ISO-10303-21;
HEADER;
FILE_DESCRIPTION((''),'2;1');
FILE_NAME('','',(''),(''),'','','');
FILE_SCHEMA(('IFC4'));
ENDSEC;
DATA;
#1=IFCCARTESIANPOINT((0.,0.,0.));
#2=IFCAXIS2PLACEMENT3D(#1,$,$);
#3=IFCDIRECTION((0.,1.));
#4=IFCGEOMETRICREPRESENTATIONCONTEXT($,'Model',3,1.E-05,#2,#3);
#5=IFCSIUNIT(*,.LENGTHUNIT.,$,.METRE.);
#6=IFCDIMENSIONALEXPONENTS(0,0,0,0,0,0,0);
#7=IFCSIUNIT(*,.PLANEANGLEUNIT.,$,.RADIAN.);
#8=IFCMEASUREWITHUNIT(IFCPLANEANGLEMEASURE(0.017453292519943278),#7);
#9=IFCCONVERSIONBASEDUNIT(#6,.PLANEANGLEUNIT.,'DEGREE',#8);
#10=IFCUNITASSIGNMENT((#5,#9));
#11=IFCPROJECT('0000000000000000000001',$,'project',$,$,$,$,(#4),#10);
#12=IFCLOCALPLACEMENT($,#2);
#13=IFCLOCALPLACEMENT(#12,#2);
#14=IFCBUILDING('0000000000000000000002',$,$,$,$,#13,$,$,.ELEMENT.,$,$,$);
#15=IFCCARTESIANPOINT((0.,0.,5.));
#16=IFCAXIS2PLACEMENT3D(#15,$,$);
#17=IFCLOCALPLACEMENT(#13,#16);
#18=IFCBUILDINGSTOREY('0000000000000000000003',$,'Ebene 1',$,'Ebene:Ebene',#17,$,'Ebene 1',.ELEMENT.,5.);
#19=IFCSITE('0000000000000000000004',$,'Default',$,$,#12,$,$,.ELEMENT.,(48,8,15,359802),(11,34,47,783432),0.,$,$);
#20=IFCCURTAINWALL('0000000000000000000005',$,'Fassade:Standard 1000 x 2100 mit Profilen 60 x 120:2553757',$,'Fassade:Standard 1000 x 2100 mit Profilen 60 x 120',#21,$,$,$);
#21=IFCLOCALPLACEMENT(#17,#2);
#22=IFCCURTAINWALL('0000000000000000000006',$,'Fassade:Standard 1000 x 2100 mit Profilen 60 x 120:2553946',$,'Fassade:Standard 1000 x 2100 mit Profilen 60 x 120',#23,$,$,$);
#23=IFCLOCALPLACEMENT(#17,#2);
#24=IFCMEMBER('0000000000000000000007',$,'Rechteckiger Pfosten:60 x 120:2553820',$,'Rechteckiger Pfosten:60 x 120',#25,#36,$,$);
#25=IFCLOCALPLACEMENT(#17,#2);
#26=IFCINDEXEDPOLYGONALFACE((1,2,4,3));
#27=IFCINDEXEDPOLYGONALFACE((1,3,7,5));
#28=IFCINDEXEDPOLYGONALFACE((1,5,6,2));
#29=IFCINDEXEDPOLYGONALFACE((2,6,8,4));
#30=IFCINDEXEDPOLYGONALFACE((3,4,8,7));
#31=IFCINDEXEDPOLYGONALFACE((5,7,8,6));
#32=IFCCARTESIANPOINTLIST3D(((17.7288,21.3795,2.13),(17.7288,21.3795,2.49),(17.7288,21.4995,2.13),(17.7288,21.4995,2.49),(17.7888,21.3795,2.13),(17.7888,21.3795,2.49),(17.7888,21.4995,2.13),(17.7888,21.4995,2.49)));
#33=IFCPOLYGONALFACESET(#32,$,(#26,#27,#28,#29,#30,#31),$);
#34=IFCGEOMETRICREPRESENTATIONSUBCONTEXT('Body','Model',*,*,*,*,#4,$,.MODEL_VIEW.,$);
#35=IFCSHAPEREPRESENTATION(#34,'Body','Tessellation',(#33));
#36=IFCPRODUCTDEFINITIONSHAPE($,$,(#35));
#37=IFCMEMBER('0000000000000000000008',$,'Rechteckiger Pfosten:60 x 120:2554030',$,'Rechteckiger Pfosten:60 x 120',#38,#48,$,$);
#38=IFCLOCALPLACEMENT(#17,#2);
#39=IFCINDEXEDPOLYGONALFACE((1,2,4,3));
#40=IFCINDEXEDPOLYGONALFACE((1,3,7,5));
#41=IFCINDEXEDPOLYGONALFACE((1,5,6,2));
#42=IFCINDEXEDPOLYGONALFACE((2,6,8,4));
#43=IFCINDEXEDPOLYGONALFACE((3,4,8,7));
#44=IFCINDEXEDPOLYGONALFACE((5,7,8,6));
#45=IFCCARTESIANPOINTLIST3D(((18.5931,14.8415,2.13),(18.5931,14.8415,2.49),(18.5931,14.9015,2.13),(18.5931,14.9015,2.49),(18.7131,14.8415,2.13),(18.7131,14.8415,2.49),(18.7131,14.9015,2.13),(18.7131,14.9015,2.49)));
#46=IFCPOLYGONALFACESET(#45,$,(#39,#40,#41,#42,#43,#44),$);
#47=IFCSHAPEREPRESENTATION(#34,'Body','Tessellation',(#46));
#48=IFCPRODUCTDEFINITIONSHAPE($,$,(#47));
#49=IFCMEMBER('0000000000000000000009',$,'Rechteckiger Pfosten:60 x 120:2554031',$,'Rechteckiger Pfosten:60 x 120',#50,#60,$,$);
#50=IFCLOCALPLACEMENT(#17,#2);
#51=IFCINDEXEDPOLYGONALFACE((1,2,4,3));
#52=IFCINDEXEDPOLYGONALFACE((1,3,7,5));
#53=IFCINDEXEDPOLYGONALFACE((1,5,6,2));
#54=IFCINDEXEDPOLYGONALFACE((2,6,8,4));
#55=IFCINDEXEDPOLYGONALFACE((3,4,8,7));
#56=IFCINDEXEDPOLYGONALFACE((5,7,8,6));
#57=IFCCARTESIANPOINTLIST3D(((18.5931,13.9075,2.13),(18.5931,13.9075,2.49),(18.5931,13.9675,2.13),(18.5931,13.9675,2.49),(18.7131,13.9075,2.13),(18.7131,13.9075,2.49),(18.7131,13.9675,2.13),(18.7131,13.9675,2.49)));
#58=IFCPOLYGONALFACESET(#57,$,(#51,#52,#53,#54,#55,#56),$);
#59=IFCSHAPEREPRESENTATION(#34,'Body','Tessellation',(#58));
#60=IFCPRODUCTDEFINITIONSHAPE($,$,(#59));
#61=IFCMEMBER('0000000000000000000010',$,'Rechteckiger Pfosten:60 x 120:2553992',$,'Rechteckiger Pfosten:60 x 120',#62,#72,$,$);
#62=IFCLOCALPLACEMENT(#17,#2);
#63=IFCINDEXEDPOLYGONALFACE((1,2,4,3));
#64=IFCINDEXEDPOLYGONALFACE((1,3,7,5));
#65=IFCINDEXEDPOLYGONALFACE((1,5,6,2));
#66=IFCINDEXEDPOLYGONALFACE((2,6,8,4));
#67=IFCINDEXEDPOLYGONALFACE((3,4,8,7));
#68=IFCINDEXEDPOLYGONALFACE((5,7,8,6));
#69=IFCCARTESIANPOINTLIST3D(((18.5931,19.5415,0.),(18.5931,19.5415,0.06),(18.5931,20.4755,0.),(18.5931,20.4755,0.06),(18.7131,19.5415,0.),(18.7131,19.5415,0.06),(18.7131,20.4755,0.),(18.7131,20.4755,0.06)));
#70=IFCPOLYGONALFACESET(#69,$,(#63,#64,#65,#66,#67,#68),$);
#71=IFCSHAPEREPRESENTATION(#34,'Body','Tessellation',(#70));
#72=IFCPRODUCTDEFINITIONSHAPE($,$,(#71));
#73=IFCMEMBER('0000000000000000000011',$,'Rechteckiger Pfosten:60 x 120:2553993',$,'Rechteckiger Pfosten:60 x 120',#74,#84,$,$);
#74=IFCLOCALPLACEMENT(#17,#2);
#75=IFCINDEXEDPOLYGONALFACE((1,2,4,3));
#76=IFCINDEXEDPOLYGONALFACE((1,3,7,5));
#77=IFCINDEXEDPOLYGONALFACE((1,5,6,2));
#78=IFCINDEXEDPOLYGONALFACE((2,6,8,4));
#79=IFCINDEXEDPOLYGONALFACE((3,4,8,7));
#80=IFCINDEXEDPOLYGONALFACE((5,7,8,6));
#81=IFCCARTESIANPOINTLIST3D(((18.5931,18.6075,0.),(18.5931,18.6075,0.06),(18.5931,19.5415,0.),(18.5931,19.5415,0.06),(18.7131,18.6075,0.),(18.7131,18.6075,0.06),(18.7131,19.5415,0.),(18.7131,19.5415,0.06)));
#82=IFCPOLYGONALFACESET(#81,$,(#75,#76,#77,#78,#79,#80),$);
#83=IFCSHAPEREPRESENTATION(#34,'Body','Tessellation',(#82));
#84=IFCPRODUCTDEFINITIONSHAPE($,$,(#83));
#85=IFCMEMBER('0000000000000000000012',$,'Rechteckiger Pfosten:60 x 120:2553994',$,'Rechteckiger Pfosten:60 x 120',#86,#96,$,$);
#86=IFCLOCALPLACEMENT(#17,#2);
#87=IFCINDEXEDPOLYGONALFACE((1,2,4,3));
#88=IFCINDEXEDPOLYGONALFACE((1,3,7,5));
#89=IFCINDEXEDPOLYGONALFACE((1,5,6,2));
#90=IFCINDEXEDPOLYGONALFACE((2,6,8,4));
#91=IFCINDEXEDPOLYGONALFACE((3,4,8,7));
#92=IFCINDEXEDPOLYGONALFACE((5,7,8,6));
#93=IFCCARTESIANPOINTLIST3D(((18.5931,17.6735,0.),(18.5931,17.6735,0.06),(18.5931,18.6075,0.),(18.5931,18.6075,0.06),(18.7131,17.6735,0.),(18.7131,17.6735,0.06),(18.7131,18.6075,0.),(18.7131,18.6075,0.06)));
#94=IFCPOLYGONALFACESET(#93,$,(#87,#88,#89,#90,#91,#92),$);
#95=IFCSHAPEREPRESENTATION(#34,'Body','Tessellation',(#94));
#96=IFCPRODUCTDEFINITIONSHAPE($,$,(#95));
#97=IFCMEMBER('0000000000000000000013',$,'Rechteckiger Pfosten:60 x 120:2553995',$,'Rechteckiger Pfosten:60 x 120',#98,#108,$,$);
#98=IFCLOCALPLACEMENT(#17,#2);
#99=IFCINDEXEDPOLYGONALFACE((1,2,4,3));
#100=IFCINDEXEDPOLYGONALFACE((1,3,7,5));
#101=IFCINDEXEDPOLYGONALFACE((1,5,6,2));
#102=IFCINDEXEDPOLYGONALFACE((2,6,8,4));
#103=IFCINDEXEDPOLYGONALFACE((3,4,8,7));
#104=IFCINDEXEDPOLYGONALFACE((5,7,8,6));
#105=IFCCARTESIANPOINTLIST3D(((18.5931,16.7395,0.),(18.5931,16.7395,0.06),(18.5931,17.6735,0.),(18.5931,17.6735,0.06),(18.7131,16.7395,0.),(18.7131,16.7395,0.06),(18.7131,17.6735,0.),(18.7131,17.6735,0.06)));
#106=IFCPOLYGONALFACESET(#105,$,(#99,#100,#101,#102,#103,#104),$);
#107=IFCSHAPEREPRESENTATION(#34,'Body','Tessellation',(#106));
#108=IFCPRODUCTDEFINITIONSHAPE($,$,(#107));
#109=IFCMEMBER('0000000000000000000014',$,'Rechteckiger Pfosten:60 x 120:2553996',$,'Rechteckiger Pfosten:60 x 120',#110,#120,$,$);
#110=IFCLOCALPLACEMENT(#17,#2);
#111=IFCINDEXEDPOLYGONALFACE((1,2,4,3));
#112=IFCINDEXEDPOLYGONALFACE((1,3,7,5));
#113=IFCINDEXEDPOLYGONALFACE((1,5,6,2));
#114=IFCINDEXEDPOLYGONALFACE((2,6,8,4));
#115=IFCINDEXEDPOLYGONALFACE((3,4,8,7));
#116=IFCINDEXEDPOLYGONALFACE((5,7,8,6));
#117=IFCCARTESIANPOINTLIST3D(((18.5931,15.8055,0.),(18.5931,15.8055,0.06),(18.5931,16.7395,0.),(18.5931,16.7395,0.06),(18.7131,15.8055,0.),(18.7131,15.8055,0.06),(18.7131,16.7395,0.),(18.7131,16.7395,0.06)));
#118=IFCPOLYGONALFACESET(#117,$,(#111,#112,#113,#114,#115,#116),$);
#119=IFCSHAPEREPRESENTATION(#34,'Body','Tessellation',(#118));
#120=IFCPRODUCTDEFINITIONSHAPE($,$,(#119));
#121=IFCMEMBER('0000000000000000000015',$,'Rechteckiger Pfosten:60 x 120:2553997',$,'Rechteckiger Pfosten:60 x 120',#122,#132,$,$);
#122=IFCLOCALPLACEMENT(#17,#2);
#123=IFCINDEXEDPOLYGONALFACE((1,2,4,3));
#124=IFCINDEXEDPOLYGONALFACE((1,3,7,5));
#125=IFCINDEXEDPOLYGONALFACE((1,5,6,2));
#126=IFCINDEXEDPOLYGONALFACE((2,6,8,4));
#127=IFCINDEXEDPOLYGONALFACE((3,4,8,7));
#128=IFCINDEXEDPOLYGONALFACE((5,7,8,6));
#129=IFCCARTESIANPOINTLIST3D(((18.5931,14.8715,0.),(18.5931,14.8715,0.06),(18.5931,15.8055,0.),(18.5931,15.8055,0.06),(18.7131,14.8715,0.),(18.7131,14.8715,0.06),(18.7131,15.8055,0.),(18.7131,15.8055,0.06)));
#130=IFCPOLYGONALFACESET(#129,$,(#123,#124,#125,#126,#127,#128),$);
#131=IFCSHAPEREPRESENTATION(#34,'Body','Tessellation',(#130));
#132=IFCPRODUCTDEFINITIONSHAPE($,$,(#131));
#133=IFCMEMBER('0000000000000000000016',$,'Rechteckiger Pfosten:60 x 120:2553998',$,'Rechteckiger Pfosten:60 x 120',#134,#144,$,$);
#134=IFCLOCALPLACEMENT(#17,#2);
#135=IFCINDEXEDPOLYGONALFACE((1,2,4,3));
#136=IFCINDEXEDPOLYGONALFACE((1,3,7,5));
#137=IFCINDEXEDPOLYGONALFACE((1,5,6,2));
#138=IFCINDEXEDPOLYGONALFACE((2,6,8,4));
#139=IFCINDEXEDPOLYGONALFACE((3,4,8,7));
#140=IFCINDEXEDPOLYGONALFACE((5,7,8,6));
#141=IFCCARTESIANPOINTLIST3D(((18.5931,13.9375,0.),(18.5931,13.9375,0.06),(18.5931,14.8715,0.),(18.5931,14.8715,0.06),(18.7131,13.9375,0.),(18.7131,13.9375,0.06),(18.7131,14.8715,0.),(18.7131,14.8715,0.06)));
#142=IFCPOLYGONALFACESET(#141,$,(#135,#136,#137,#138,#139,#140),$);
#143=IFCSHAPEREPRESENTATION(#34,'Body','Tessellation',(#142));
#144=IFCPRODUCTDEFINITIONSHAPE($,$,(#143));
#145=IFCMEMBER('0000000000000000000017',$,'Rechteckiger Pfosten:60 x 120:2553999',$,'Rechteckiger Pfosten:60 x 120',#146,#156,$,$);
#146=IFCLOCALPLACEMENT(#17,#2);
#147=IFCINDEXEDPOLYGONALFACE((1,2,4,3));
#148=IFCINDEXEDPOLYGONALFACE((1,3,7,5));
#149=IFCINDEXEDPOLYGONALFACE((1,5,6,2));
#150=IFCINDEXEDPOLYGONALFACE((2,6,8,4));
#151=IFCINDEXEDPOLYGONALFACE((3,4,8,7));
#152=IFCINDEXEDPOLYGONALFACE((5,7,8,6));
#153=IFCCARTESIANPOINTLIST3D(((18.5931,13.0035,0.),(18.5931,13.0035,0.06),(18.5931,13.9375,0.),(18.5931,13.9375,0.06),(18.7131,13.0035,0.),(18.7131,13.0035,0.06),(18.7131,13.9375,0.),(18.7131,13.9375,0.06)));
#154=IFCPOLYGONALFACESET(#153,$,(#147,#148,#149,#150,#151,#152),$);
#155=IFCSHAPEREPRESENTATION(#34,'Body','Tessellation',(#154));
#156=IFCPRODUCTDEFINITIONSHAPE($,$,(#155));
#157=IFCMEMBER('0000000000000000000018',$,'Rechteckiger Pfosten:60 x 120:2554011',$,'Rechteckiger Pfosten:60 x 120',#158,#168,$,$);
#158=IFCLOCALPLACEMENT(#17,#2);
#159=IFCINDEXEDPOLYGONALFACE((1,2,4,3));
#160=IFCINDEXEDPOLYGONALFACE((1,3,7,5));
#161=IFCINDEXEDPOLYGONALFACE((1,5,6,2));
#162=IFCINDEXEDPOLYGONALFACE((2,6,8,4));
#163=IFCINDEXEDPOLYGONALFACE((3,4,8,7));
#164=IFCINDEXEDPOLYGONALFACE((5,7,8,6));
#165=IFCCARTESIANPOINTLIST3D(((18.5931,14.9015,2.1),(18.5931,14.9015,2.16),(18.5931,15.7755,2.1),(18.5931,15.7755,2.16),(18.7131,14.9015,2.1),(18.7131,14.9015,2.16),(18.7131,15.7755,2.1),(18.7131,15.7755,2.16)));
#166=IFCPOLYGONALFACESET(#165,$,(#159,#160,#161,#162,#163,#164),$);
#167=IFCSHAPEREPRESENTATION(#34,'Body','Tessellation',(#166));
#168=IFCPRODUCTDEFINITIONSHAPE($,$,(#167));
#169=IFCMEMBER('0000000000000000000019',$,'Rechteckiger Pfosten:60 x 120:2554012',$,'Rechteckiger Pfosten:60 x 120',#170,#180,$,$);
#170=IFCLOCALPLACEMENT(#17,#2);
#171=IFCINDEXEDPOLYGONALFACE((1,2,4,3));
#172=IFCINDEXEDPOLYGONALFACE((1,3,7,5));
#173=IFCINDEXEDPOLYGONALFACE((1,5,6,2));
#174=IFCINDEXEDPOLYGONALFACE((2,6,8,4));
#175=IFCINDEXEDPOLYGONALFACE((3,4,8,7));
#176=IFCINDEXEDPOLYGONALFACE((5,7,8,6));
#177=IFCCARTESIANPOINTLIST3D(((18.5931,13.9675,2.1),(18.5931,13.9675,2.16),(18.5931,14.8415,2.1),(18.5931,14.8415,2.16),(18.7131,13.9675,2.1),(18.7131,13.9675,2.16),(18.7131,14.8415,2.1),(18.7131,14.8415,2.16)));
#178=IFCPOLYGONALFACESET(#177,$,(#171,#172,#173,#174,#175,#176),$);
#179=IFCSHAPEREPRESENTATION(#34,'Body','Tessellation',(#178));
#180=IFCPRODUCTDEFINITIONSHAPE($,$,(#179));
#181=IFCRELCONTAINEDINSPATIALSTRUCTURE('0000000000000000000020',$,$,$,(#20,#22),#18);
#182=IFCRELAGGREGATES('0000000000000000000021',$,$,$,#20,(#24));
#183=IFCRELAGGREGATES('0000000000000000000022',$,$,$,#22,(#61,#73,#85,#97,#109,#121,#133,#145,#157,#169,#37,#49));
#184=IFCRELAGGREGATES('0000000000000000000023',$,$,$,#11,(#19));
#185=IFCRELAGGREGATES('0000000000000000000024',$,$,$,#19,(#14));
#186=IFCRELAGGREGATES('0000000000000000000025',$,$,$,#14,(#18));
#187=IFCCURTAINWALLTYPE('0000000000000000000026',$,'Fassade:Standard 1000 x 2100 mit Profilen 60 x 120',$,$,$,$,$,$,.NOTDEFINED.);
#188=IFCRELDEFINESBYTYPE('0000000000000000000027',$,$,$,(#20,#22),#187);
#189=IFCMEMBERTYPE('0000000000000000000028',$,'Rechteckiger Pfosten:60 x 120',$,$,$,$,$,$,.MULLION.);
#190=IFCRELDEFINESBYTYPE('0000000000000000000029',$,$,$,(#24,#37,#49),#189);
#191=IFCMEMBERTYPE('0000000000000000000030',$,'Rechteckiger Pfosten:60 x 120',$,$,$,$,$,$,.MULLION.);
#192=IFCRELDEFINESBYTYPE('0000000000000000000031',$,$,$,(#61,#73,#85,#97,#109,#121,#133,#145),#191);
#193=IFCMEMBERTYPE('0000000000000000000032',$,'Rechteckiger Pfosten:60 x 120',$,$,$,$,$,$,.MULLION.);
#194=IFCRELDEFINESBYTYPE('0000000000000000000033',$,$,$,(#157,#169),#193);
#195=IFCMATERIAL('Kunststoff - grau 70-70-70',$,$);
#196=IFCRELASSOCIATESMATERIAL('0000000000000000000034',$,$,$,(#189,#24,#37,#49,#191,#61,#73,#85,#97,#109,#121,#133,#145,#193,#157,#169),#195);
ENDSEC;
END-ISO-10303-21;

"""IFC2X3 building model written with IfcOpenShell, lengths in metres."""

from ifc_helpers import new_model, entity, si_unit, converted_unit, direction, frame, frame_2d, origin, origin_2d_with_axis, place, context, subcontext, project, spatial, rectangle, extrude, source, transform, mapped, material, type_object, type_shapes, element, aggregate, save


model = new_model("IFC2X3")

# Units and contexts
model_context = context("Model", 3, precision=1e-05, world=origin(), true_north=direction((0.0, 1.0)))
body_context = subcontext(model_context, "Body", "Model", "MODEL_VIEW")
ifc_project = project(units=[si_unit("LENGTHUNIT", "METRE"), converted_unit("PLANEANGLEUNIT", "DEGREE", entity("IfcPlaneAngleMeasure", 0.017453292519943278), si_unit("PLANEANGLEUNIT", "RADIAN"), dimensions=[0, 0, 0, 0, 0, 0, 0])], contexts=[model_context])

# Site, building, storey
site_placement = place(None, origin())
site = spatial("IfcSite", under=ifc_project, at=site_placement, Name="Default", CompositionType="ELEMENT", RefLatitude=(48, 8, 15, 359802), RefLongitude=(11, 34, 47, 783432), RefElevation=0.0)
building_placement = place(site_placement, origin())
building = spatial("IfcBuilding", under=site, at=building_placement, CompositionType="ELEMENT")
storey_placement = place(building_placement, frame((0.0, 0.0, 5.0)))
storey = spatial("IfcBuildingStorey", under=building, at=storey_placement, Name="Ebene 1", ObjectType="Ebene:Ebene", LongName="Ebene 1", CompositionType="ELEMENT", Elevation=5.0)

# Curtain walls
curtain_wall_type = type_object("IfcCurtainWallType", Name="Fassade:Standard 1000 x 2100 mit Profilen 60 x 120", PredefinedType="NOTDEFINED")
curtain_wall_1_placement = place(storey_placement, frame((0.0, 0.0, -5.0)))
curtain_wall_1 = element("IfcCurtainWall", 1, at=curtain_wall_1_placement, inside=storey, type_object=curtain_wall_type, Name="Fassade:Standard 1000 x 2100 mit Profilen 60 x 120:2553757", ObjectType="Fassade:Standard 1000 x 2100 mit Profilen 60 x 120")
ifc_material_1 = material(Name="Kunststoff - grau 70-70-70")
curtain_wall_2_placement = place(storey_placement, frame((0.0, 0.0, -5.0)))
curtain_wall_2 = element("IfcCurtainWall", 2, at=curtain_wall_2_placement, inside=storey, type_object=curtain_wall_type, Name="Fassade:Standard 1000 x 2100 mit Profilen 60 x 120:2553946", ObjectType="Fassade:Standard 1000 x 2100 mit Profilen 60 x 120")

# Members
member_type_1 = type_object("IfcMemberType", Name="Rechteckiger Pfosten:60 x 120", PredefinedType="MULLION", material=ifc_material_1)
shared_shape_1 = source(origin(), body_context, "Body", "SweptSolid", [
    extrude(rectangle(XDim=0.06, YDim=0.12, at=frame_2d((0.0, 0.0), x_axis=(1.0, 0.0))), frame((0.0, 0.0, -0.36), z_axis=(0.0, 0.0, 1.0), x_axis=(-1.0, 0.0, 0.0)), (0.0, 0.0, 1.0), 0.36),
])
type_shapes(member_type_1, [shared_shape_1])
member_1_placement = place(curtain_wall_1_placement, frame((17.7588, 21.4395, 7.13), z_axis=(0.0, 0.0, -1.0), x_axis=(1.0, 0.0, 0.0)))
member_1 = element("IfcMember", 3, at=member_1_placement, type_object=member_type_1, material=ifc_material_1, Name="Rechteckiger Pfosten:60 x 120:2553820", ObjectType="Rechteckiger Pfosten:60 x 120", context=body_context, shape_type="MappedRepresentation", body=[
    mapped(shared_shape_1, transform((0.0, 0.0, 0.0), scale=1.0)),
])
member_2_placement = place(curtain_wall_2_placement, frame((18.6531, 14.8715, 7.13), z_axis=(0.0, 0.0, -1.0), x_axis=(0.0, -1.0, 0.0)))
member_2 = element("IfcMember", 4, at=member_2_placement, type_object=member_type_1, material=ifc_material_1, Name="Rechteckiger Pfosten:60 x 120:2554030", ObjectType="Rechteckiger Pfosten:60 x 120", context=body_context, shape_type="MappedRepresentation", body=[
    mapped(shared_shape_1, transform((0.0, 0.0, 0.0), scale=1.0)),
])
member_3_placement = place(curtain_wall_2_placement, frame((18.6531, 13.9375, 7.13), z_axis=(0.0, 0.0, -1.0), x_axis=(0.0, -1.0, 0.0)))
member_3 = element("IfcMember", 5, at=member_3_placement, type_object=member_type_1, material=ifc_material_1, Name="Rechteckiger Pfosten:60 x 120:2554031", ObjectType="Rechteckiger Pfosten:60 x 120", context=body_context, shape_type="MappedRepresentation", body=[
    mapped(shared_shape_1, transform((0.0, 0.0, 0.0), scale=1.0)),
])
member_type_2 = type_object("IfcMemberType", Name="Rechteckiger Pfosten:60 x 120", PredefinedType="MULLION", material=ifc_material_1)
shared_shape_2 = source(origin(), body_context, "Body", "SweptSolid", [
    extrude(rectangle(XDim=0.06, YDim=0.12, at=origin_2d_with_axis()), frame((-0.03, 0.0, -0.934), z_axis=(0.0, 0.0, 1.0), x_axis=(-1.0, 0.0, 0.0)), (0.0, 0.0, 1.0), 0.934),
])
type_shapes(member_type_2, [shared_shape_2])
member_4_placement = place(curtain_wall_2_placement, frame((18.6531, 20.4755, 5.0), z_axis=(0.0, 1.0, 0.0), x_axis=(0.0, 0.0, -1.0)))
member_4 = element("IfcMember", 6, at=member_4_placement, type_object=member_type_2, material=ifc_material_1, Name="Rechteckiger Pfosten:60 x 120:2553992", ObjectType="Rechteckiger Pfosten:60 x 120", context=body_context, shape_type="MappedRepresentation", body=[
    mapped(shared_shape_2, transform((0.0, 0.0, 0.0), scale=1.0)),
])
member_5_placement = place(curtain_wall_2_placement, frame((18.6531, 19.5415, 5.0), z_axis=(0.0, 1.0, 0.0), x_axis=(0.0, 0.0, -1.0)))
member_5 = element("IfcMember", 7, at=member_5_placement, type_object=member_type_2, material=ifc_material_1, Name="Rechteckiger Pfosten:60 x 120:2553993", ObjectType="Rechteckiger Pfosten:60 x 120", context=body_context, shape_type="MappedRepresentation", body=[
    mapped(shared_shape_2, transform((0.0, 0.0, 0.0), scale=1.0)),
])
member_6_placement = place(curtain_wall_2_placement, frame((18.6531, 18.6075, 5.0), z_axis=(0.0, 1.0, 0.0), x_axis=(0.0, 0.0, -1.0)))
member_6 = element("IfcMember", 8, at=member_6_placement, type_object=member_type_2, material=ifc_material_1, Name="Rechteckiger Pfosten:60 x 120:2553994", ObjectType="Rechteckiger Pfosten:60 x 120", context=body_context, shape_type="MappedRepresentation", body=[
    mapped(shared_shape_2, transform((0.0, 0.0, 0.0), scale=1.0)),
])
member_7_placement = place(curtain_wall_2_placement, frame((18.6531, 17.6735, 5.0), z_axis=(0.0, 1.0, 0.0), x_axis=(0.0, 0.0, -1.0)))
member_7 = element("IfcMember", 9, at=member_7_placement, type_object=member_type_2, material=ifc_material_1, Name="Rechteckiger Pfosten:60 x 120:2553995", ObjectType="Rechteckiger Pfosten:60 x 120", context=body_context, shape_type="MappedRepresentation", body=[
    mapped(shared_shape_2, transform((0.0, 0.0, 0.0), scale=1.0)),
])
member_8_placement = place(curtain_wall_2_placement, frame((18.6531, 16.7395, 5.0), z_axis=(0.0, 1.0, 0.0), x_axis=(0.0, 0.0, -1.0)))
member_8 = element("IfcMember", 10, at=member_8_placement, type_object=member_type_2, material=ifc_material_1, Name="Rechteckiger Pfosten:60 x 120:2553996", ObjectType="Rechteckiger Pfosten:60 x 120", context=body_context, shape_type="MappedRepresentation", body=[
    mapped(shared_shape_2, transform((0.0, 0.0, 0.0), scale=1.0)),
])
member_9_placement = place(curtain_wall_2_placement, frame((18.6531, 15.8055, 5.0), z_axis=(0.0, 1.0, 0.0), x_axis=(0.0, 0.0, -1.0)))
member_9 = element("IfcMember", 11, at=member_9_placement, type_object=member_type_2, material=ifc_material_1, Name="Rechteckiger Pfosten:60 x 120:2553997", ObjectType="Rechteckiger Pfosten:60 x 120", context=body_context, shape_type="MappedRepresentation", body=[
    mapped(shared_shape_2, transform((0.0, 0.0, 0.0), scale=1.0)),
])
member_10_placement = place(curtain_wall_2_placement, frame((18.6531, 14.8715, 5.0), z_axis=(0.0, 1.0, 0.0), x_axis=(0.0, 0.0, -1.0)))
member_10 = element("IfcMember", 12, at=member_10_placement, type_object=member_type_2, material=ifc_material_1, Name="Rechteckiger Pfosten:60 x 120:2553998", ObjectType="Rechteckiger Pfosten:60 x 120", context=body_context, shape_type="MappedRepresentation", body=[
    mapped(shared_shape_2, transform((0.0, 0.0, 0.0), scale=1.0)),
])
member_11_placement = place(curtain_wall_2_placement, frame((18.6531, 13.9375, 5.0), z_axis=(0.0, 1.0, 0.0), x_axis=(0.0, 0.0, -1.0)))
member_11 = element("IfcMember", 13, at=member_11_placement, type_object=member_type_2, material=ifc_material_1, Name="Rechteckiger Pfosten:60 x 120:2553999", ObjectType="Rechteckiger Pfosten:60 x 120", context=body_context, shape_type="MappedRepresentation", body=[
    mapped(shared_shape_2, transform((0.0, 0.0, 0.0), scale=1.0)),
])
member_type_3 = type_object("IfcMemberType", Name="Rechteckiger Pfosten:60 x 120", PredefinedType="MULLION", material=ifc_material_1)
shared_shape_3 = source(origin(), body_context, "Body", "SweptSolid", [
    extrude(rectangle(XDim=0.06, YDim=0.12, at=frame_2d((0.0, 0.0), x_axis=(1.0, 0.0))), frame((0.0, 0.0, -0.874), z_axis=(0.0, 0.0, 1.0), x_axis=(-1.0, 0.0, 0.0)), (0.0, 0.0, 1.0), 0.874),
])
type_shapes(member_type_3, [shared_shape_3])
member_12_placement = place(curtain_wall_2_placement, frame((18.6531, 14.9015, 7.13), z_axis=(0.0, -1.0, 0.0), x_axis=(0.0, 0.0, 1.0)))
member_12 = element("IfcMember", 14, at=member_12_placement, type_object=member_type_3, material=ifc_material_1, Name="Rechteckiger Pfosten:60 x 120:2554011", ObjectType="Rechteckiger Pfosten:60 x 120", context=body_context, shape_type="MappedRepresentation", body=[
    mapped(shared_shape_3, transform((0.0, 0.0, 0.0), scale=1.0)),
])
member_13_placement = place(curtain_wall_2_placement, frame((18.6531, 13.9675, 7.13), z_axis=(0.0, -1.0, 0.0), x_axis=(0.0, 0.0, 1.0)))
member_13 = element("IfcMember", 15, at=member_13_placement, type_object=member_type_3, material=ifc_material_1, Name="Rechteckiger Pfosten:60 x 120:2554012", ObjectType="Rechteckiger Pfosten:60 x 120", context=body_context, shape_type="MappedRepresentation", body=[
    mapped(shared_shape_3, transform((0.0, 0.0, 0.0), scale=1.0)),
])

aggregate(curtain_wall_1, [member_1])
aggregate(curtain_wall_2, [member_4, member_5, member_6, member_7, member_8, member_9, member_10, member_11, member_12, member_13, member_2, member_3])

save(model, "model.ifc")
